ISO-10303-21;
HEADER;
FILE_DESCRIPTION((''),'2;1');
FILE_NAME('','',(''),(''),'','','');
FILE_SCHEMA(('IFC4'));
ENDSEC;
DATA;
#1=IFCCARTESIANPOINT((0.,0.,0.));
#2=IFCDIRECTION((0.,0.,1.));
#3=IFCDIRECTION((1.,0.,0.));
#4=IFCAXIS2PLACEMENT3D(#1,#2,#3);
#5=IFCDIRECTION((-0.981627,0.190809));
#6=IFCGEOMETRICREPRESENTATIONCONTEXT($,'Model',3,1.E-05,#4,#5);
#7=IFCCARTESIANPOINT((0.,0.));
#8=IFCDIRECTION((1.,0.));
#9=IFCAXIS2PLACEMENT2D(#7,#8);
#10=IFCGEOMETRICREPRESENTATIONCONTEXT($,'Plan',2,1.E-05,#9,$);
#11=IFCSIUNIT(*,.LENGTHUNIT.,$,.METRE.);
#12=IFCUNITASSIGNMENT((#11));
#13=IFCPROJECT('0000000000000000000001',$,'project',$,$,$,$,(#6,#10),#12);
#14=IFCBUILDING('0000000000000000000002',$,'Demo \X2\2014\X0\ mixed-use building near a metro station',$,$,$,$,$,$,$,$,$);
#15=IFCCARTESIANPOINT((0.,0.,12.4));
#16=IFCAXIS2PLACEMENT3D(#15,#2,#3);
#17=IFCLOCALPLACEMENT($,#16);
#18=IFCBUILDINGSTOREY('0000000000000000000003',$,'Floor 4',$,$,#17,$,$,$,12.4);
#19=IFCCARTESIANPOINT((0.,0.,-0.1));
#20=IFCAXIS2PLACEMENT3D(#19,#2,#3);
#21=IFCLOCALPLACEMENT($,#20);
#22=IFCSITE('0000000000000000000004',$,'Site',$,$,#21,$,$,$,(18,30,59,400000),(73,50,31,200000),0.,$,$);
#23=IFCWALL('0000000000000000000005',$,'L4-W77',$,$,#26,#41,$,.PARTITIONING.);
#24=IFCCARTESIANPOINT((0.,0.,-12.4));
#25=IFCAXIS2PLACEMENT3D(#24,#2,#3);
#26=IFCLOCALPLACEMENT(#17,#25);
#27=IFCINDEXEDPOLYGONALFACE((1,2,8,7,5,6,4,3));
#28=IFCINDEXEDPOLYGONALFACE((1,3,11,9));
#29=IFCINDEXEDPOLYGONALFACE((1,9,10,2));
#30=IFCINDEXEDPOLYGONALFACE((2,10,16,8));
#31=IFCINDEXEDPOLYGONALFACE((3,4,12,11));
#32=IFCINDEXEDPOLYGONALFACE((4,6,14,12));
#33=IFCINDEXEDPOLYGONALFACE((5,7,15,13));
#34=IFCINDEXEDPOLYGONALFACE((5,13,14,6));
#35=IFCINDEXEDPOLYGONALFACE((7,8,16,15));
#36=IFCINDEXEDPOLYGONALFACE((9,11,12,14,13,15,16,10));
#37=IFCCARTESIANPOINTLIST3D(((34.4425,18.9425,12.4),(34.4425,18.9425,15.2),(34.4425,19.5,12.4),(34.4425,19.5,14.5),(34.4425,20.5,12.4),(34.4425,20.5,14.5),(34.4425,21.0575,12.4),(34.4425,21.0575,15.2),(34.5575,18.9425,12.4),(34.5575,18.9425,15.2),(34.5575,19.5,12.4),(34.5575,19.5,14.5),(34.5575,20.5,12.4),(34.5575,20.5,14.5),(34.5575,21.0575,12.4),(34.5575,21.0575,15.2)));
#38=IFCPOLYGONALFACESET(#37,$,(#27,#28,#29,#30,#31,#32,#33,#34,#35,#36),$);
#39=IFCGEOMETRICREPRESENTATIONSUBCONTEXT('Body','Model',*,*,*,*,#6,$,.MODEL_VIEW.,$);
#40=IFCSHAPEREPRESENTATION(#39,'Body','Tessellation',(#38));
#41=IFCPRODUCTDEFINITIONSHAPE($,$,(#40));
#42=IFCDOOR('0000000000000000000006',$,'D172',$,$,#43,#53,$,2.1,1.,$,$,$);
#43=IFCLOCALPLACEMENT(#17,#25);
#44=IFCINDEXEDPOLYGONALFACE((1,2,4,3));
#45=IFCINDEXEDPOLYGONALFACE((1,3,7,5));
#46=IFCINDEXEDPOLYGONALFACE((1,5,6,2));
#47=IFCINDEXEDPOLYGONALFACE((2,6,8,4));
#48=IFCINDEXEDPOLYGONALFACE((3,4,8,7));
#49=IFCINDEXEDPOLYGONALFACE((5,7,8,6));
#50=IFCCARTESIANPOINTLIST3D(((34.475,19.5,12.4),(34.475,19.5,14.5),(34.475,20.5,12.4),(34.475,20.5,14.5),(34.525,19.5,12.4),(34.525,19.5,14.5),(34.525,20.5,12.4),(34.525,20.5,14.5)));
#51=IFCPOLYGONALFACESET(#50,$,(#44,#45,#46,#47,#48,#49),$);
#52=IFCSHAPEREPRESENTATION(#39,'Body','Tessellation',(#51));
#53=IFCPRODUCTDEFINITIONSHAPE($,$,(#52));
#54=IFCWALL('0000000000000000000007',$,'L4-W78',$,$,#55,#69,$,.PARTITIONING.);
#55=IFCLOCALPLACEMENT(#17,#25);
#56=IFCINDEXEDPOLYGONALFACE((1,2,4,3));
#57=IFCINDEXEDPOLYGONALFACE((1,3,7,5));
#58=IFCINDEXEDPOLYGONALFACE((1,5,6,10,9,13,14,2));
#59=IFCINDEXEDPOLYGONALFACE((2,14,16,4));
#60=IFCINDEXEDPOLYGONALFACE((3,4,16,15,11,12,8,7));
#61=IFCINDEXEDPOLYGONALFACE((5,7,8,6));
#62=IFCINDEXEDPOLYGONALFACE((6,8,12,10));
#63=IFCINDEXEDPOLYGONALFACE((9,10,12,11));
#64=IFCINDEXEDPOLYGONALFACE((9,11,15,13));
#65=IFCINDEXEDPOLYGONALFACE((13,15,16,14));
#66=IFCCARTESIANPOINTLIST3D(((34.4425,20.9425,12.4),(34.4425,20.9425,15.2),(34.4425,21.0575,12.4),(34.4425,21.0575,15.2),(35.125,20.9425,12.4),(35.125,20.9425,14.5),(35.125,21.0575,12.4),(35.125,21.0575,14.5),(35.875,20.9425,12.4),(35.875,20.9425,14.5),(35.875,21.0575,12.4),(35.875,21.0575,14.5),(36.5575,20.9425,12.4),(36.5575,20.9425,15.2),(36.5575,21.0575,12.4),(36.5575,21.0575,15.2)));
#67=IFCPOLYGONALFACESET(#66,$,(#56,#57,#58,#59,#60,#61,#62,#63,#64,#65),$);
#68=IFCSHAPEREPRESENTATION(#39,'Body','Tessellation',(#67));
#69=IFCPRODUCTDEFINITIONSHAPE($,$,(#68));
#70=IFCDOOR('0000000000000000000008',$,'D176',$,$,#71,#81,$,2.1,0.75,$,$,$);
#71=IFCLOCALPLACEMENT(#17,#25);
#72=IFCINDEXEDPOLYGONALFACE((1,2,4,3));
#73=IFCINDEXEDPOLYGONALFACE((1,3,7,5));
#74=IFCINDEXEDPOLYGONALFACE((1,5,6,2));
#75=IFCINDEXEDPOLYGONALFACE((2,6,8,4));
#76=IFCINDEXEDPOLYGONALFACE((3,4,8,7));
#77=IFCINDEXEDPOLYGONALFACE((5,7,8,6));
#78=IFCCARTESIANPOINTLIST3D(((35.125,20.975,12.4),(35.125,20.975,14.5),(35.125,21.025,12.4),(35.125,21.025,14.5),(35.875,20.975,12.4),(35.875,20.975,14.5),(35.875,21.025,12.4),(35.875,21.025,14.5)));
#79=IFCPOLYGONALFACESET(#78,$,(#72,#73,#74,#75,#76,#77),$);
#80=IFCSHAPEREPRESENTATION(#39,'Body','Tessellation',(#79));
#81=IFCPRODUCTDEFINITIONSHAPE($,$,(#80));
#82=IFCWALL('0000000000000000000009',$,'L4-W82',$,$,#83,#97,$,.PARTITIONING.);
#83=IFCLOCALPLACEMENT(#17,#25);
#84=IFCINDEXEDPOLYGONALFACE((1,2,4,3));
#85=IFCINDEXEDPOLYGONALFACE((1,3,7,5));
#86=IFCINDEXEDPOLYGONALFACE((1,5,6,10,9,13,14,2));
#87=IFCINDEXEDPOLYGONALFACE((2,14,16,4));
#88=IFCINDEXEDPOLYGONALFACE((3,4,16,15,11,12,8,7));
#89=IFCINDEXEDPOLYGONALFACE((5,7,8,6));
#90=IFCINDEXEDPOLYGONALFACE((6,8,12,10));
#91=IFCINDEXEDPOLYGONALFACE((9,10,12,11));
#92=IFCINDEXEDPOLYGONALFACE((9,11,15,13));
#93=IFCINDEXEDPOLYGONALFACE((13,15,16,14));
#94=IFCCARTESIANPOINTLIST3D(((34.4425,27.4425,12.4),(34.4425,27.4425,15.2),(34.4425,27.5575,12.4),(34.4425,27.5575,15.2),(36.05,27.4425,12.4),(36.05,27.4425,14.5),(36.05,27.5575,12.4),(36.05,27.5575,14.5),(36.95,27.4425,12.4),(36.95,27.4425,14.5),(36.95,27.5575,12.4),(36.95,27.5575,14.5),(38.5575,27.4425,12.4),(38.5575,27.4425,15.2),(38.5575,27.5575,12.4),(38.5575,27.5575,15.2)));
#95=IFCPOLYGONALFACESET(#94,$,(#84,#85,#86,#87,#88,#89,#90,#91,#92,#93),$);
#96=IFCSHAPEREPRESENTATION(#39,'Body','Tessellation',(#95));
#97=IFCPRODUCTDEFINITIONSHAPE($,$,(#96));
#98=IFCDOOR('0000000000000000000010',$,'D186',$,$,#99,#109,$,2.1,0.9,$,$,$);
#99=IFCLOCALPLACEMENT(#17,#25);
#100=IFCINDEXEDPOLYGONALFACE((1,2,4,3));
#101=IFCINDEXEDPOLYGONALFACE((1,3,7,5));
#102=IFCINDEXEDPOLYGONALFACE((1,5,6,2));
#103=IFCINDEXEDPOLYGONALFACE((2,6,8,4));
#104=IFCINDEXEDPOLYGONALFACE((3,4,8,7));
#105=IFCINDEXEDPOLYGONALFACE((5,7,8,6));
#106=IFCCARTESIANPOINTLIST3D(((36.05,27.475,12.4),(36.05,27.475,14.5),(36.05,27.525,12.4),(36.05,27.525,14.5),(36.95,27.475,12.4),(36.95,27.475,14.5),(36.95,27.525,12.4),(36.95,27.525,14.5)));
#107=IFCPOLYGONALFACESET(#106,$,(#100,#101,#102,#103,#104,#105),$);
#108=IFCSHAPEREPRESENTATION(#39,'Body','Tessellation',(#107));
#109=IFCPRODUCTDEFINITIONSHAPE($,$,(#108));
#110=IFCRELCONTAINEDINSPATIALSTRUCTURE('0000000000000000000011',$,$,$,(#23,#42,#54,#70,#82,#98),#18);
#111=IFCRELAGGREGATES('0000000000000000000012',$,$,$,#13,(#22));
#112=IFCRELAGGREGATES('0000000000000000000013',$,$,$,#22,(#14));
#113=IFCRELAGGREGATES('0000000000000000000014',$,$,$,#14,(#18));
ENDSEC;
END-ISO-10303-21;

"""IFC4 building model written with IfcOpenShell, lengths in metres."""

from ifc_helpers import new_model, si_unit, direction, frame, origin_with_axes, origin_2d_with_axis, place, context, subcontext, project, spatial, line, indexed_curve, outline, extrude, element, fill, save


model = new_model("IFC4")

# Units and contexts
model_context = context("Model", 3, precision=1e-05, world=origin_with_axes(), true_north=direction((-0.981627, 0.190809)))
plan_context = context("Plan", 2, precision=1e-05, world=origin_2d_with_axis())
body_context = subcontext(model_context, "Body", "Model", "MODEL_VIEW")
ifc_project = project(units=[si_unit("LENGTHUNIT", "METRE")], contexts=[model_context, plan_context])

# Site, building, storey
site_placement = place(None, frame((0.0, 0.0, -0.1), z_axis=(0.0, 0.0, 1.0), x_axis=(1.0, 0.0, 0.0)))
site = spatial("IfcSite", under=ifc_project, at=site_placement, Name="Site", RefLatitude=(18, 30, 59, 400000), RefLongitude=(73, 50, 31, 200000), RefElevation=0.0)
building = spatial("IfcBuilding", under=site, Name="Demo — mixed-use building near a metro station")
storey_placement = place(None, frame((0.0, 0.0, 12.4), z_axis=(0.0, 0.0, 1.0), x_axis=(1.0, 0.0, 0.0)))
storey = spatial("IfcBuildingStorey", under=building, at=storey_placement, Name="Floor 4", Elevation=12.4)

# Walls, openings, doors
wall_1_placement = place(storey_placement, frame((0.0, 0.0, -12.4), z_axis=(0.0, 0.0, 1.0), x_axis=(1.0, 0.0, 0.0)))
wall_1 = element("IfcWall", 1, at=wall_1_placement, inside=storey, Name="L4-W77", PredefinedType="PARTITIONING", context=body_context, shape_type="SweptSolid", body=[
    extrude(outline(indexed_curve([(34.4425, 18.9425), (34.4425, 21.0575), (34.5575, 21.0575), (34.5575, 18.9425)], segments=[line(1, 2, 3, 4, 1)])), frame((0.0, 0.0, 12.4), z_axis=(0.0, 0.0, 1.0), x_axis=(1.0, 0.0, 0.0)), (0.0, 0.0, 1.0), 2.8),
])
opening_1_placement = place(wall_1_placement, origin_with_axes())
opening_1 = element("IfcOpeningElement", 2, at=opening_1_placement, cuts=wall_1, context=body_context, shape_type="SweptSolid", body=[
    extrude(outline(indexed_curve([(34.3925, 19.5), (34.3925, 20.5), (34.6075, 20.5), (34.6075, 19.5)], segments=[line(1, 2, 3, 4, 1)])), frame((0.0, 0.0, 12.4), z_axis=(0.0, 0.0, 1.0), x_axis=(1.0, 0.0, 0.0)), (0.0, 0.0, 1.0), 2.1),
])
door_1_placement = place(storey_placement, frame((0.0, 0.0, -12.4), z_axis=(0.0, 0.0, 1.0), x_axis=(1.0, 0.0, 0.0)))
door_1 = element("IfcDoor", 3, at=door_1_placement, inside=storey, Name="D172", OverallHeight=2.1, OverallWidth=1.0, context=body_context, shape_type="SweptSolid", body=[
    extrude(outline(indexed_curve([(34.475, 19.5), (34.475, 20.5), (34.525, 20.5), (34.525, 19.5)], segments=[line(1, 2, 3, 4, 1)])), frame((0.0, 0.0, 12.4), z_axis=(0.0, 0.0, 1.0), x_axis=(1.0, 0.0, 0.0)), (0.0, 0.0, 1.0), 2.1),
])
fill(opening_1, door_1)
wall_2_placement = place(storey_placement, frame((0.0, 0.0, -12.4), z_axis=(0.0, 0.0, 1.0), x_axis=(1.0, 0.0, 0.0)))
wall_2 = element("IfcWall", 4, at=wall_2_placement, inside=storey, Name="L4-W78", PredefinedType="PARTITIONING", context=body_context, shape_type="SweptSolid", body=[
    extrude(outline(indexed_curve([(36.5575, 20.9425), (34.4425, 20.9425), (34.4425, 21.0575), (36.5575, 21.0575)], segments=[line(1, 2, 3, 4, 1)])), frame((0.0, 0.0, 12.4), z_axis=(0.0, 0.0, 1.0), x_axis=(1.0, 0.0, 0.0)), (0.0, 0.0, 1.0), 2.8),
])
opening_2_placement = place(wall_2_placement, origin_with_axes())
opening_2 = element("IfcOpeningElement", 5, at=opening_2_placement, cuts=wall_2, context=body_context, shape_type="SweptSolid", body=[
    extrude(outline(indexed_curve([(35.875, 20.8925), (35.125, 20.8925), (35.125, 21.1075), (35.875, 21.1075)], segments=[line(1, 2, 3, 4, 1)])), frame((0.0, 0.0, 12.4), z_axis=(0.0, 0.0, 1.0), x_axis=(1.0, 0.0, 0.0)), (0.0, 0.0, 1.0), 2.1),
])
door_2_placement = place(storey_placement, frame((0.0, 0.0, -12.4), z_axis=(0.0, 0.0, 1.0), x_axis=(1.0, 0.0, 0.0)))
door_2 = element("IfcDoor", 6, at=door_2_placement, inside=storey, Name="D176", OverallHeight=2.1, OverallWidth=0.75, context=body_context, shape_type="SweptSolid", body=[
    extrude(outline(indexed_curve([(35.875, 20.975), (35.125, 20.975), (35.125, 21.025), (35.875, 21.025)], segments=[line(1, 2, 3, 4, 1)])), frame((0.0, 0.0, 12.4), z_axis=(0.0, 0.0, 1.0), x_axis=(1.0, 0.0, 0.0)), (0.0, 0.0, 1.0), 2.1),
])
fill(opening_2, door_2)

# Wall, opening, door
wall_3_placement = place(storey_placement, frame((0.0, 0.0, -12.4), z_axis=(0.0, 0.0, 1.0), x_axis=(1.0, 0.0, 0.0)))
wall_3 = element("IfcWall", 7, at=wall_3_placement, inside=storey, Name="L4-W82", PredefinedType="PARTITIONING", context=body_context, shape_type="SweptSolid", body=[
    extrude(outline(indexed_curve([(38.5575, 27.4425), (34.4425, 27.4425), (34.4425, 27.5575), (38.5575, 27.5575)], segments=[line(1, 2, 3, 4, 1)])), frame((0.0, 0.0, 12.4), z_axis=(0.0, 0.0, 1.0), x_axis=(1.0, 0.0, 0.0)), (0.0, 0.0, 1.0), 2.8),
])
opening_3_placement = place(wall_3_placement, origin_with_axes())
opening_3 = element("IfcOpeningElement", 8, at=opening_3_placement, cuts=wall_3, context=body_context, shape_type="SweptSolid", body=[
    extrude(outline(indexed_curve([(36.95, 27.3925), (36.05, 27.3925), (36.05, 27.6075), (36.95, 27.6075)], segments=[line(1, 2, 3, 4, 1)])), frame((0.0, 0.0, 12.4), z_axis=(0.0, 0.0, 1.0), x_axis=(1.0, 0.0, 0.0)), (0.0, 0.0, 1.0), 2.1),
])
door_3_placement = place(storey_placement, frame((0.0, 0.0, -12.4), z_axis=(0.0, 0.0, 1.0), x_axis=(1.0, 0.0, 0.0)))
door_3 = element("IfcDoor", 9, at=door_3_placement, inside=storey, Name="D186", OverallHeight=2.1, OverallWidth=0.9, context=body_context, shape_type="SweptSolid", body=[
    extrude(outline(indexed_curve([(36.95, 27.475), (36.05, 27.475), (36.05, 27.525), (36.95, 27.525)], segments=[line(1, 2, 3, 4, 1)])), frame((0.0, 0.0, 12.4), z_axis=(0.0, 0.0, 1.0), x_axis=(1.0, 0.0, 0.0)), (0.0, 0.0, 1.0), 2.1),
])
fill(opening_3, door_3)

save(model, "model.ifc")
